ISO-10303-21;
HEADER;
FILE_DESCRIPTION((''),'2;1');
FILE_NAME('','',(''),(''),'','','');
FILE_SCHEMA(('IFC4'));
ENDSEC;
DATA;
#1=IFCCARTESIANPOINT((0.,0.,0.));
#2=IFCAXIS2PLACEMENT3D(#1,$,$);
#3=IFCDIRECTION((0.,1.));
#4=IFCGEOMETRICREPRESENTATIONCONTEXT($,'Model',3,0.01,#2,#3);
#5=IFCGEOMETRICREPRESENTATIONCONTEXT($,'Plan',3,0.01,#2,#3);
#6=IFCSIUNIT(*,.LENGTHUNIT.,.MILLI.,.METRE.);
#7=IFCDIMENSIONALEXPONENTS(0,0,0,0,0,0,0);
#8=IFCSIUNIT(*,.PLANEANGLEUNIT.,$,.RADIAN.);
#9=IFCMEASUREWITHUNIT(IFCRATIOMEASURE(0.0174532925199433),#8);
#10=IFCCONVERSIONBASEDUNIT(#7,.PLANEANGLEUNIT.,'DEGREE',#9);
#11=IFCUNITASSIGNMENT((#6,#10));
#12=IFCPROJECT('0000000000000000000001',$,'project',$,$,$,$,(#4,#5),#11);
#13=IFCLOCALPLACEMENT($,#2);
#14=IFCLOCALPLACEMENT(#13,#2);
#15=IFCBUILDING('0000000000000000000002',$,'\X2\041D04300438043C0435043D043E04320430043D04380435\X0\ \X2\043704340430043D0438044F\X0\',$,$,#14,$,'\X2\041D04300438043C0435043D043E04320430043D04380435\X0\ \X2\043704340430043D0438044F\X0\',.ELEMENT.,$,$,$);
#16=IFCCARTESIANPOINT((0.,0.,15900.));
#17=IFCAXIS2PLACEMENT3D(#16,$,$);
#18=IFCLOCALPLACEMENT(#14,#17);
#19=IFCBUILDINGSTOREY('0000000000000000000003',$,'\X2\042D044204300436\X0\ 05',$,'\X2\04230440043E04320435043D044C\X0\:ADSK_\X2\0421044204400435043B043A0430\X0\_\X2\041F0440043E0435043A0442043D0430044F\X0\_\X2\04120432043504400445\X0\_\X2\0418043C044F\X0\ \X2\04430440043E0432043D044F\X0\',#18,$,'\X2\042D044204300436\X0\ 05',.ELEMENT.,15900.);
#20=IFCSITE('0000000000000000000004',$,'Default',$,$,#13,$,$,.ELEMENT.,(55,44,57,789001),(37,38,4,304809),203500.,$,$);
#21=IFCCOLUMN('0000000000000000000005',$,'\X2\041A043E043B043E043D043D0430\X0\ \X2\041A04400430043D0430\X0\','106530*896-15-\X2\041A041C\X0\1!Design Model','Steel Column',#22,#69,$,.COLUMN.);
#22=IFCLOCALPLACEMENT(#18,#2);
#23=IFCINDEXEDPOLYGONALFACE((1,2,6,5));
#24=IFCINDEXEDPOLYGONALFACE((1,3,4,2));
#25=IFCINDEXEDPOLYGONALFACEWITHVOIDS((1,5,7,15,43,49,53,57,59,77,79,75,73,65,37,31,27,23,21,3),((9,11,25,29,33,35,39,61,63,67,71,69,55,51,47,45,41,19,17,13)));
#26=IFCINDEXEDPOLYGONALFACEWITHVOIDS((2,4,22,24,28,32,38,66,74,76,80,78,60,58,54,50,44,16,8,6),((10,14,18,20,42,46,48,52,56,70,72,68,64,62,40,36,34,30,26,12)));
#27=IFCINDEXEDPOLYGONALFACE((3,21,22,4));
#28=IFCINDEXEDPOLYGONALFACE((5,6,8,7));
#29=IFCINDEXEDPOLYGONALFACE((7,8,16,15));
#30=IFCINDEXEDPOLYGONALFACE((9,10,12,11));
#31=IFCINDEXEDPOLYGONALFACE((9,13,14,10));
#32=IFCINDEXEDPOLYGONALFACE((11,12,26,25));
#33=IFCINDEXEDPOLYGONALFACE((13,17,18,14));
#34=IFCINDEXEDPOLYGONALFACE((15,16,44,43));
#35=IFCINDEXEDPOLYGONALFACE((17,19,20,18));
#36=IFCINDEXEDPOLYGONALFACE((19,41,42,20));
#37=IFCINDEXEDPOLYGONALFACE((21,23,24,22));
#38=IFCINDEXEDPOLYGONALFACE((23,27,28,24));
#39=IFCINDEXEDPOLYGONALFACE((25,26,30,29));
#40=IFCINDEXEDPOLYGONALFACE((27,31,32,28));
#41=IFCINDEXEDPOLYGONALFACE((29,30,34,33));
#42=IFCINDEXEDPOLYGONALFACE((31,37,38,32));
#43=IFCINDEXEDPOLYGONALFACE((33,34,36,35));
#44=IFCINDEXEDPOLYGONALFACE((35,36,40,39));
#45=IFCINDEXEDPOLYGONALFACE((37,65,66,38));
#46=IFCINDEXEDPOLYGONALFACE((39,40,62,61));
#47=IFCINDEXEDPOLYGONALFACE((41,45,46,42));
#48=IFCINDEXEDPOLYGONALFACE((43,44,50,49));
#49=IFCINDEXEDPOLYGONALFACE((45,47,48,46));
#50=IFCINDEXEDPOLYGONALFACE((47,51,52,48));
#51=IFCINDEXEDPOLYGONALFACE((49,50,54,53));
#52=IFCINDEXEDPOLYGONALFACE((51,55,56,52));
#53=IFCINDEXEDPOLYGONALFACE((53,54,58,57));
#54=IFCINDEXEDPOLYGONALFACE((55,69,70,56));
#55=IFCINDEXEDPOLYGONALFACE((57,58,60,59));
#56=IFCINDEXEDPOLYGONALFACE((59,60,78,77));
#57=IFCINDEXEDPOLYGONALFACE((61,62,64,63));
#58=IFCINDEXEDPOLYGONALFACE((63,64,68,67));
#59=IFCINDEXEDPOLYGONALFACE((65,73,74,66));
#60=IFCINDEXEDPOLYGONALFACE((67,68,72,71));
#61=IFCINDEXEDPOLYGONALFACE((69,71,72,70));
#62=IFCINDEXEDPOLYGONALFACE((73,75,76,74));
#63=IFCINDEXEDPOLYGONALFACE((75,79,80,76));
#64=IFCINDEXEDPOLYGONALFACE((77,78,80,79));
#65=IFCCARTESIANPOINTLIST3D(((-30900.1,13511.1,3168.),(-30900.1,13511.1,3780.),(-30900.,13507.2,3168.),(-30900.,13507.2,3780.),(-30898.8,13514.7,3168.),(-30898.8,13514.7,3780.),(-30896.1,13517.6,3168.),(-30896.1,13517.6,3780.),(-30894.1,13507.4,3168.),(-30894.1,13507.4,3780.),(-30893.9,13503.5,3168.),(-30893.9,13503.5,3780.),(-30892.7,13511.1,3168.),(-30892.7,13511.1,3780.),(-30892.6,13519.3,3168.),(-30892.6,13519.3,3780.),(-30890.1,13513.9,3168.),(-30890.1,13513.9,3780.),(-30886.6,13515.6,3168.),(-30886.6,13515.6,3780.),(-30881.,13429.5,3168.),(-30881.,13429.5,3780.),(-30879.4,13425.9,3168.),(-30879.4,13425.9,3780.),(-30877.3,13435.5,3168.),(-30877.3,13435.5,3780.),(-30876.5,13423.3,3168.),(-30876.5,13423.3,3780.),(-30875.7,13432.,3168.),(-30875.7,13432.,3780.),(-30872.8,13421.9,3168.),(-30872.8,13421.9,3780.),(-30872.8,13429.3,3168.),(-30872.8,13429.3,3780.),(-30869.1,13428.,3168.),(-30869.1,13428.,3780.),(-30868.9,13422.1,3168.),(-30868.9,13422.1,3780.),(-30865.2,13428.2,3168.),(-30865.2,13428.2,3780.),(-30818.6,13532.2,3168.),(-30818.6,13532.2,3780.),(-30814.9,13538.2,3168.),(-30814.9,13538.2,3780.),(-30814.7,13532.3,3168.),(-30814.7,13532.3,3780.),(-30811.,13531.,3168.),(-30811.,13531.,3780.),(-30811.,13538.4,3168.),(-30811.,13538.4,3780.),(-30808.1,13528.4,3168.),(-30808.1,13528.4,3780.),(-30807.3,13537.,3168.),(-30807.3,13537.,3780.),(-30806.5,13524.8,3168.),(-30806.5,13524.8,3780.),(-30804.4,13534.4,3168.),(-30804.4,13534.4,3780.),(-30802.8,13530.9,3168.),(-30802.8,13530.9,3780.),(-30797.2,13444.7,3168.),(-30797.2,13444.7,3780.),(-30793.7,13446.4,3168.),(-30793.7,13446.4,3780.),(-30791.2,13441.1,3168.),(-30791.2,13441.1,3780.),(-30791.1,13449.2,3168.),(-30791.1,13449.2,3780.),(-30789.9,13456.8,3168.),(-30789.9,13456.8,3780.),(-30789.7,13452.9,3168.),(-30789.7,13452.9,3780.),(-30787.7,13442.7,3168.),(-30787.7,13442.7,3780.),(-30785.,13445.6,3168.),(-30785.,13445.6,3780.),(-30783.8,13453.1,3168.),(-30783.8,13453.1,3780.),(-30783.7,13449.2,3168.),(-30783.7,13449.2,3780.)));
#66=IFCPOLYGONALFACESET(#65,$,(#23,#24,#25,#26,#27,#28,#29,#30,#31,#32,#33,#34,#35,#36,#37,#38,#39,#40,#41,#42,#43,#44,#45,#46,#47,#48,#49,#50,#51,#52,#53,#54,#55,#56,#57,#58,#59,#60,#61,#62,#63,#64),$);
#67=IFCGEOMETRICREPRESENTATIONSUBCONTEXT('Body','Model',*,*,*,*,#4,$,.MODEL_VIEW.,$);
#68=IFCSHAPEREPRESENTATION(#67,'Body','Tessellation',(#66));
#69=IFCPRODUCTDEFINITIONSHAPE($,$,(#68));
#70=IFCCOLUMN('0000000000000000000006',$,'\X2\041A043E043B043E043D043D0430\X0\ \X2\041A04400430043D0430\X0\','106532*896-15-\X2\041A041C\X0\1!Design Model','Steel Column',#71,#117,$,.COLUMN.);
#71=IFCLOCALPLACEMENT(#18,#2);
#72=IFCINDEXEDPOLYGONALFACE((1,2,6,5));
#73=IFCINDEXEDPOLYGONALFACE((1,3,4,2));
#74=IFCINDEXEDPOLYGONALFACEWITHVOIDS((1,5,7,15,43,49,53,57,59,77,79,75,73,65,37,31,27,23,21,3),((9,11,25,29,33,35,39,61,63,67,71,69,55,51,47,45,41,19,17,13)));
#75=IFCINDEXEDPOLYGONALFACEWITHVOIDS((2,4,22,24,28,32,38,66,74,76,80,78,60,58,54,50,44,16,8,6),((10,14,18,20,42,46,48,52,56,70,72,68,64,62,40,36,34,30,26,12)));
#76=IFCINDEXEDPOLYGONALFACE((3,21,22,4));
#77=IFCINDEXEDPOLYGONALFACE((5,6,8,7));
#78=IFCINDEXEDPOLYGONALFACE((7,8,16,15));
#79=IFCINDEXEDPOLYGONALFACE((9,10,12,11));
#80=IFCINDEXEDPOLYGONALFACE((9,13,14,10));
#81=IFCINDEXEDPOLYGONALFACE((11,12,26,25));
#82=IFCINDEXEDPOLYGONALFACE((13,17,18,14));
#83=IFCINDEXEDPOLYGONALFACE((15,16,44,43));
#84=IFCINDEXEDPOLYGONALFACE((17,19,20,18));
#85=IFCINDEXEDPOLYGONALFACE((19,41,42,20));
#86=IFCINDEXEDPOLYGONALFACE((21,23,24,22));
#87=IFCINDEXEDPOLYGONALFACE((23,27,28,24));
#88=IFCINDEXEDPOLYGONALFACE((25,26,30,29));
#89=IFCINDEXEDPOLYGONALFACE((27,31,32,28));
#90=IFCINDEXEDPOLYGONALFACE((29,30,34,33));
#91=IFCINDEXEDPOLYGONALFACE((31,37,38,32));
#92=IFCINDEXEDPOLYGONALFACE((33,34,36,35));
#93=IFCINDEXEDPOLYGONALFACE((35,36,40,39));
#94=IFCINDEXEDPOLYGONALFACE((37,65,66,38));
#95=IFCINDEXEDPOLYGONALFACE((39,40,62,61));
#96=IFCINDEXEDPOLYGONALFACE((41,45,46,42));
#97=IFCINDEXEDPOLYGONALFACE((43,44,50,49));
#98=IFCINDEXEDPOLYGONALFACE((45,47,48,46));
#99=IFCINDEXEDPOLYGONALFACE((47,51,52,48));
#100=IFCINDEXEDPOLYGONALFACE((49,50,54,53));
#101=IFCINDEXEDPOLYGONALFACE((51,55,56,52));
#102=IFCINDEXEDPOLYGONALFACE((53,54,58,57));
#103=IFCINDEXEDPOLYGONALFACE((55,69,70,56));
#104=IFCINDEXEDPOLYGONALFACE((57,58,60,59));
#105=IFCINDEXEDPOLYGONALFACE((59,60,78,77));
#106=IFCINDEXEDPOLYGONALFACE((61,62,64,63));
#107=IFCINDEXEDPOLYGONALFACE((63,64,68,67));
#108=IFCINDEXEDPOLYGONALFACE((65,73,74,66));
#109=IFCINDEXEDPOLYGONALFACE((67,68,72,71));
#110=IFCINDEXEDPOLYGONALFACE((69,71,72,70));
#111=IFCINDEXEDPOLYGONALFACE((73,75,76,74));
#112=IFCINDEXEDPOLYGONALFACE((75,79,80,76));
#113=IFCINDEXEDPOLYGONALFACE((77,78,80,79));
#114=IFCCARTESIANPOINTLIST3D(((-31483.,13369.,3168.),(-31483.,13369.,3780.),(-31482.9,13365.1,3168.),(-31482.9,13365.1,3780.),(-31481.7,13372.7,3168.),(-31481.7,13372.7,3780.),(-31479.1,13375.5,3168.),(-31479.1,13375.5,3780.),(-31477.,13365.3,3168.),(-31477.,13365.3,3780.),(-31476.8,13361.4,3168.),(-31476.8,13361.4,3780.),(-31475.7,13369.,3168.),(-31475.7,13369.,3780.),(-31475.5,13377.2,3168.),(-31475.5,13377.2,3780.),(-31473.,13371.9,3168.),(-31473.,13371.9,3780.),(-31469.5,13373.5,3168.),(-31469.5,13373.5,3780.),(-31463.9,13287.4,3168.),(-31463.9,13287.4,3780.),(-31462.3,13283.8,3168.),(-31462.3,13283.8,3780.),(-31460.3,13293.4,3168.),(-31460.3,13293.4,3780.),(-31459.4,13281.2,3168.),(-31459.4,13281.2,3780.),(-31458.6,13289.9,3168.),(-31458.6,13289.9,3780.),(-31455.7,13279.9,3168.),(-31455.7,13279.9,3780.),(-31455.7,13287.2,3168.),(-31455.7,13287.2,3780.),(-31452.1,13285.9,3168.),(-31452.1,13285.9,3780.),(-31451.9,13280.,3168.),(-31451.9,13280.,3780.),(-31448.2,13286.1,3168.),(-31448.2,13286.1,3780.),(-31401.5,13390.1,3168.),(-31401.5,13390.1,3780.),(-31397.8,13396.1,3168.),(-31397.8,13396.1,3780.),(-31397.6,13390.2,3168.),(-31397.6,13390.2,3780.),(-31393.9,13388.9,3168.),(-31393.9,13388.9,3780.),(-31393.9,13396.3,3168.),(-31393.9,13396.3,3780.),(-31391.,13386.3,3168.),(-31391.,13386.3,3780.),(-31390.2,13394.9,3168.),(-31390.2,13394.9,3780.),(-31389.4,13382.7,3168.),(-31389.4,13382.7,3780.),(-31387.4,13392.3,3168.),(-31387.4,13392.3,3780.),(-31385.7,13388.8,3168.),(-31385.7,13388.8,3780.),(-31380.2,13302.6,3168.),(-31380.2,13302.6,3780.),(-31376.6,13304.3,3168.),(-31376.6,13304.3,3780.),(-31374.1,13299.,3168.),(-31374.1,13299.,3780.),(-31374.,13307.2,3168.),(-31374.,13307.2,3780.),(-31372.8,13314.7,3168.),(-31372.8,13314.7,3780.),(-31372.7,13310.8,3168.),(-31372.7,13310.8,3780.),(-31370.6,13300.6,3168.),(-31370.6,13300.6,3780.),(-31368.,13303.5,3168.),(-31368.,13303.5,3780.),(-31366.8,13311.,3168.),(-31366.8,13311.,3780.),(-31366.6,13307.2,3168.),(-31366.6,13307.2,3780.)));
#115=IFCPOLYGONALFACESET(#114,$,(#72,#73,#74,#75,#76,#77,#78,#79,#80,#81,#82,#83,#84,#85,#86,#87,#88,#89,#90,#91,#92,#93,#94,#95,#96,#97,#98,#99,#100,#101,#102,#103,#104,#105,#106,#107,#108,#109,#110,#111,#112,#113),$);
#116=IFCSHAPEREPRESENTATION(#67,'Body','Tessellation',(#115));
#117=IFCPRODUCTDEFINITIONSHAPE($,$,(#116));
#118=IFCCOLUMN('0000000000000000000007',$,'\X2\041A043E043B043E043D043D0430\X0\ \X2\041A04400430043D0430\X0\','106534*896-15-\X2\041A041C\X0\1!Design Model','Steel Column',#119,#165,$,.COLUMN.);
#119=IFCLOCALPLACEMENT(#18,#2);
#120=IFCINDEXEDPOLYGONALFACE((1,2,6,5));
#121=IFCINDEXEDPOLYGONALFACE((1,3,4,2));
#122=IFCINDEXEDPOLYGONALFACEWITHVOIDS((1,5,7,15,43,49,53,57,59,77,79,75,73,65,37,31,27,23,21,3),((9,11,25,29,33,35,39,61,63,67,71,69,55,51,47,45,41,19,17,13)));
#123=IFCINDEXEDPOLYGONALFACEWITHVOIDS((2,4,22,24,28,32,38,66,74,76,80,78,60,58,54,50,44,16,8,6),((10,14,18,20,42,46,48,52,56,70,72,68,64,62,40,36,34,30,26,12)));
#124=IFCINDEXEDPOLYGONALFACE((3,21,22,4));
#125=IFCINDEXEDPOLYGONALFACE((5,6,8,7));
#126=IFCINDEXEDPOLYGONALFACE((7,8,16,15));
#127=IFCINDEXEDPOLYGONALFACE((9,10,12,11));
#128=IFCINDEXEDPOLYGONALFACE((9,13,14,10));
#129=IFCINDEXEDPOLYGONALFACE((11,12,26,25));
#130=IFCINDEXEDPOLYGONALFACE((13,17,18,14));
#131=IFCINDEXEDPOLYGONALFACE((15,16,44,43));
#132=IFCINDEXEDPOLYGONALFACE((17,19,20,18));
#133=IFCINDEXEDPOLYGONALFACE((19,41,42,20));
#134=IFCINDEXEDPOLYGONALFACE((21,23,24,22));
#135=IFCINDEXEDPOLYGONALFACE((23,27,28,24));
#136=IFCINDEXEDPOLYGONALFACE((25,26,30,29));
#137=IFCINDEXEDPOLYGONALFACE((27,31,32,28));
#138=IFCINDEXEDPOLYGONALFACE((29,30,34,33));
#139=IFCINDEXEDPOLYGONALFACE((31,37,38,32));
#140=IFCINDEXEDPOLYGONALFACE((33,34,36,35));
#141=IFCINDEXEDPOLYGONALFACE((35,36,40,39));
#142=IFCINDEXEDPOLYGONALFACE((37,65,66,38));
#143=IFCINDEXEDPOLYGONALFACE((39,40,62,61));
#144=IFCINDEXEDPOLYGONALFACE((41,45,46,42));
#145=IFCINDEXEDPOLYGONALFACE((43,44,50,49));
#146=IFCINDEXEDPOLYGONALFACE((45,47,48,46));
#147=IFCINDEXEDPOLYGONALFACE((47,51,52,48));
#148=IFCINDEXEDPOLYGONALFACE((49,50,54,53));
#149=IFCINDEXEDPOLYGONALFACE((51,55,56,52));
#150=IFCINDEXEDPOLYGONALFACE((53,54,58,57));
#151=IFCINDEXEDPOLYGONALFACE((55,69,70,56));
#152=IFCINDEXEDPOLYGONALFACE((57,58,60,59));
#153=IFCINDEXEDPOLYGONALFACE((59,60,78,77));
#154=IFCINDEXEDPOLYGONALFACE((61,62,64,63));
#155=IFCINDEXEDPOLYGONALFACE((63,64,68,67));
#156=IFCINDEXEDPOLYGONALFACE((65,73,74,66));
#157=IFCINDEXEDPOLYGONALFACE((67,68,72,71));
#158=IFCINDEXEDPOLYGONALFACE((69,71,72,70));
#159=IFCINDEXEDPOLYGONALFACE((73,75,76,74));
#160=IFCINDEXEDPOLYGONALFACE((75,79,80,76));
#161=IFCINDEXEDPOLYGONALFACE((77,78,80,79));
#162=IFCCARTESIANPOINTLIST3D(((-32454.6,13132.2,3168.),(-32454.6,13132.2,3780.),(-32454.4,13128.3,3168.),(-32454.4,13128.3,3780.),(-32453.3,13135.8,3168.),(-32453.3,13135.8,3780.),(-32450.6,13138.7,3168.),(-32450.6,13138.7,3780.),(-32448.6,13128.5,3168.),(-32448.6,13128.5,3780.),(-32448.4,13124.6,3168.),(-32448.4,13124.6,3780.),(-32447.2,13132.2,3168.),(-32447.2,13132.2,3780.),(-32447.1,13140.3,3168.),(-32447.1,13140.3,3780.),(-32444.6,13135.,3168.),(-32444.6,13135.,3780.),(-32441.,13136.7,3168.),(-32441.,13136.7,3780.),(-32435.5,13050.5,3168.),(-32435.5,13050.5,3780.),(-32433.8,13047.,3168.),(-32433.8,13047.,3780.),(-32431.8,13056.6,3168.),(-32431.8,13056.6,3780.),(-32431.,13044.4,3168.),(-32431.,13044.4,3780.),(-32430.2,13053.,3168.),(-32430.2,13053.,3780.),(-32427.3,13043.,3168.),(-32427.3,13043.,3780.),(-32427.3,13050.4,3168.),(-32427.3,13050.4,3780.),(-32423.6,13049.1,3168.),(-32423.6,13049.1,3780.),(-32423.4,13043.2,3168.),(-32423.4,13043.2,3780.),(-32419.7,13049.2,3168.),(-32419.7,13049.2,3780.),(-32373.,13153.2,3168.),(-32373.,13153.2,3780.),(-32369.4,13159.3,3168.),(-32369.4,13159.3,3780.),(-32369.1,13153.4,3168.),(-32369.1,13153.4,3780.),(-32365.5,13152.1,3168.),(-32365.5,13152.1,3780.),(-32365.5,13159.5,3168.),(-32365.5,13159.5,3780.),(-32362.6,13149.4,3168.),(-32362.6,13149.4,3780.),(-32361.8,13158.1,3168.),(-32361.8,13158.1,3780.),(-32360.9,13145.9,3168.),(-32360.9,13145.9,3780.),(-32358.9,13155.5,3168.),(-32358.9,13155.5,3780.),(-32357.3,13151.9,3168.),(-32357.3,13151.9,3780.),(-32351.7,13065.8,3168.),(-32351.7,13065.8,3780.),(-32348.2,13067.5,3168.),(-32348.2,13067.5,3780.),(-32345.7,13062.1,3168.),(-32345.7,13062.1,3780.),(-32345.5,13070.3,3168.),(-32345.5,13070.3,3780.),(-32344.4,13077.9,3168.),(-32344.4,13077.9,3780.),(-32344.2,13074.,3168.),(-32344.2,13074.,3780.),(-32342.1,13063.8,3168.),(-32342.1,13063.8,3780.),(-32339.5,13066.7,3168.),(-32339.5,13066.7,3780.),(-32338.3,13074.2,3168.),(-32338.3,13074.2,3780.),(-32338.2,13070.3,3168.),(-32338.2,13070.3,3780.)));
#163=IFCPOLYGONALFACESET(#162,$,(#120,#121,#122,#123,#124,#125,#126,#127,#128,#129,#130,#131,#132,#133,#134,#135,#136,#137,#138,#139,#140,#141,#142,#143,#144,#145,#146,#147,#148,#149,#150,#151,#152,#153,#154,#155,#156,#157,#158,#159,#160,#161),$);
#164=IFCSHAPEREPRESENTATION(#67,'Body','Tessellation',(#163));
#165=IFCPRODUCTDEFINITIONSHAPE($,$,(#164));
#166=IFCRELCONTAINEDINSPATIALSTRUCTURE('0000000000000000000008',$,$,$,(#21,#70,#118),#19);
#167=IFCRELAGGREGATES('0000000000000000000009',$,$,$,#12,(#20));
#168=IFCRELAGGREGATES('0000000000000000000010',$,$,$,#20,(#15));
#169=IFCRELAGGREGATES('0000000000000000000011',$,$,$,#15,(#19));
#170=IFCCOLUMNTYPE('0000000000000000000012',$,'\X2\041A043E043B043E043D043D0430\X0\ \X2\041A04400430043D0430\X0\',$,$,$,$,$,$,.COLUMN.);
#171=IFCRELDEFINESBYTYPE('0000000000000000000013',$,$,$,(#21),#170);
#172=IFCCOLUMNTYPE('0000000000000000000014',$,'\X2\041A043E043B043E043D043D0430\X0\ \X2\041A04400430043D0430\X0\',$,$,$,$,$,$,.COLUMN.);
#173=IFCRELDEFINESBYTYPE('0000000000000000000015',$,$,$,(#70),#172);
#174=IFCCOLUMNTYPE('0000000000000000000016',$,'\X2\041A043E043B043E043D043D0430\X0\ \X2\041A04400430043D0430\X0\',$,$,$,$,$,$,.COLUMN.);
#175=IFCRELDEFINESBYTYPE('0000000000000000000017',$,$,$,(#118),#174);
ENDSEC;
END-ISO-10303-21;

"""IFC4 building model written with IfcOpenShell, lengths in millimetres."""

from ifc_helpers import new_model, entity, si_unit, converted_unit, direction, frame, origin, place, context, subcontext, project, spatial, indexed_curve, outline, extrude, type_object, element, save


model = new_model("IFC4")

# Units and contexts
model_context = context("Model", 3, precision=0.01, world=origin(), true_north=direction((0.0, 1.0)))
plan_context = context("Plan", 3, precision=0.01, world=origin(), true_north=direction((0.0, 1.0)))
body_context = subcontext(model_context, "Body", "Model", "MODEL_VIEW")
ifc_project = project(units=[si_unit("LENGTHUNIT", "METRE", prefix="MILLI"), converted_unit("PLANEANGLEUNIT", "DEGREE", entity("IfcRatioMeasure", 0.0174532925199433), si_unit("PLANEANGLEUNIT", "RADIAN"), dimensions=[0, 0, 0, 0, 0, 0, 0])], contexts=[model_context, plan_context])

# Site, building, storey
site_placement = place(None, origin())
site = spatial("IfcSite", under=ifc_project, at=site_placement, Name="Default", CompositionType="ELEMENT", RefLatitude=(55, 44, 57, 789001), RefLongitude=(37, 38, 4, 304809), RefElevation=203500.0)
building_placement = place(site_placement, origin())
building = spatial("IfcBuilding", under=site, at=building_placement, Name="Наименование здания", LongName="Наименование здания", CompositionType="ELEMENT")
storey_placement = place(building_placement, frame((0.0, 0.0, 15900.0)))
storey = spatial("IfcBuildingStorey", under=building, at=storey_placement, Name="Этаж 05", ObjectType="Уровень:ADSK_Стрелка_Проектная_Вверх_Имя уровня", LongName="Этаж 05", CompositionType="ELEMENT", Elevation=15900.0)

# Columns
placement = place(storey_placement, origin())
column_type_1 = type_object("IfcColumnType", Name="Колонна Крана", PredefinedType="COLUMN")
element("IfcColumn", 1, at=placement, inside=storey, type_object=column_type_1, Name="Колонна Крана", Description="106530*896-15-КМ1!Design Model", ObjectType="Steel Column", PredefinedType="COLUMN", context=body_context, shape_type="SweptSolid", body=[
    extrude(outline(indexed_curve([(29.5, -56.8), (33.4, -56.8), (37.0, -55.3), (39.7, -52.6), (41.2, -49.0), (56.8, 29.5), (56.8, 33.4), (55.3, 37.0), (52.6, 39.7), (49.0, 41.2), (-29.5, 56.8), (-33.4, 56.8), (-37.0, 55.3), (-39.7, 52.6), (-41.2, 49.0), (-56.8, -29.5), (-56.8, -33.4), (-55.3, -37.0), (-52.6, -39.7), (-49.0, -41.2), (29.5, -56.8)], self_intersect=False), holes=[indexed_curve([(-43.1, -37.3), (-46.7, -35.8), (-49.5, -33.1), (-51.0, -29.5), (-51.0, -25.5), (-37.3, 43.1), (-35.8, 46.7), (-33.1, 49.5), (-29.5, 51.0), (-25.5, 51.0), (43.1, 37.3), (46.7, 35.8), (49.5, 33.1), (51.0, 29.5), (51.0, 25.5), (37.3, -43.1), (35.8, -46.7), (33.1, -49.5), (29.5, -51.0), (25.5, -51.0), (-43.1, -37.3)], self_intersect=False)]), frame((-30841.9, 13480.2, 3168.0), z_axis=(0.0, 0.0, 1.0), x_axis=(0.906681, 0.421816, 0.0)), (0.0, 0.0, 1.0), 612.0),
])
column_type_2 = type_object("IfcColumnType", Name="Колонна Крана", PredefinedType="COLUMN")
element("IfcColumn", 2, at=placement, inside=storey, type_object=column_type_2, Name="Колонна Крана", Description="106532*896-15-КМ1!Design Model", ObjectType="Steel Column", PredefinedType="COLUMN", context=body_context, shape_type="SweptSolid", body=[
    extrude(outline(indexed_curve([(29.5, -56.8), (33.4, -56.8), (37.0, -55.3), (39.7, -52.6), (41.2, -49.0), (56.8, 29.5), (56.8, 33.4), (55.3, 37.0), (52.6, 39.7), (49.0, 41.2), (-29.5, 56.8), (-33.4, 56.8), (-37.0, 55.3), (-39.7, 52.6), (-41.2, 49.0), (-56.8, -29.5), (-56.8, -33.4), (-55.3, -37.0), (-52.6, -39.7), (-49.0, -41.2), (29.5, -56.8)], self_intersect=False), holes=[indexed_curve([(-43.1, -37.3), (-46.7, -35.8), (-49.5, -33.1), (-51.0, -29.5), (-51.0, -25.5), (-37.3, 43.1), (-35.8, 46.7), (-33.1, 49.5), (-29.5, 51.0), (-25.5, 51.0), (43.1, 37.3), (46.7, 35.8), (49.5, 33.1), (51.0, 29.5), (51.0, 25.5), (37.3, -43.1), (35.8, -46.7), (33.1, -49.5), (29.5, -51.0), (25.5, -51.0), (-43.1, -37.3)], self_intersect=False)]), frame((-31424.8, 13338.1, 3168.0), z_axis=(0.0, 0.0, 1.0), x_axis=(0.906681, 0.421816, 0.0)), (0.0, 0.0, 1.0), 612.0),
])
column_type_3 = type_object("IfcColumnType", Name="Колонна Крана", PredefinedType="COLUMN")
element("IfcColumn", 3, at=placement, inside=storey, type_object=column_type_3, Name="Колонна Крана", Description="106534*896-15-КМ1!Design Model", ObjectType="Steel Column", PredefinedType="COLUMN", context=body_context, shape_type="SweptSolid", body=[
    extrude(outline(indexed_curve([(29.5, -56.8), (33.4, -56.8), (37.0, -55.3), (39.7, -52.6), (41.2, -49.0), (56.8, 29.5), (56.8, 33.4), (55.3, 37.0), (52.6, 39.7), (49.0, 41.2), (-29.5, 56.8), (-33.4, 56.8), (-37.0, 55.3), (-39.7, 52.6), (-41.2, 49.0), (-56.8, -29.5), (-56.8, -33.4), (-55.3, -37.0), (-52.6, -39.7), (-49.0, -41.2), (29.5, -56.8)], self_intersect=False), holes=[indexed_curve([(-43.1, -37.3), (-46.7, -35.8), (-49.5, -33.1), (-51.0, -29.5), (-51.0, -25.5), (-37.3, 43.1), (-35.8, 46.7), (-33.1, 49.5), (-29.5, 51.0), (-25.5, 51.0), (43.1, 37.3), (46.7, 35.8), (49.5, 33.1), (51.0, 29.5), (51.0, 25.5), (37.3, -43.1), (35.8, -46.7), (33.1, -49.5), (29.5, -51.0), (25.5, -51.0), (-43.1, -37.3)], self_intersect=False)]), frame((-32396.4, 13101.2, 3168.0), z_axis=(0.0, 0.0, 1.0), x_axis=(0.906681, 0.421816, 0.0)), (0.0, 0.0, 1.0), 612.0),
])

save(model, "model.ifc")
